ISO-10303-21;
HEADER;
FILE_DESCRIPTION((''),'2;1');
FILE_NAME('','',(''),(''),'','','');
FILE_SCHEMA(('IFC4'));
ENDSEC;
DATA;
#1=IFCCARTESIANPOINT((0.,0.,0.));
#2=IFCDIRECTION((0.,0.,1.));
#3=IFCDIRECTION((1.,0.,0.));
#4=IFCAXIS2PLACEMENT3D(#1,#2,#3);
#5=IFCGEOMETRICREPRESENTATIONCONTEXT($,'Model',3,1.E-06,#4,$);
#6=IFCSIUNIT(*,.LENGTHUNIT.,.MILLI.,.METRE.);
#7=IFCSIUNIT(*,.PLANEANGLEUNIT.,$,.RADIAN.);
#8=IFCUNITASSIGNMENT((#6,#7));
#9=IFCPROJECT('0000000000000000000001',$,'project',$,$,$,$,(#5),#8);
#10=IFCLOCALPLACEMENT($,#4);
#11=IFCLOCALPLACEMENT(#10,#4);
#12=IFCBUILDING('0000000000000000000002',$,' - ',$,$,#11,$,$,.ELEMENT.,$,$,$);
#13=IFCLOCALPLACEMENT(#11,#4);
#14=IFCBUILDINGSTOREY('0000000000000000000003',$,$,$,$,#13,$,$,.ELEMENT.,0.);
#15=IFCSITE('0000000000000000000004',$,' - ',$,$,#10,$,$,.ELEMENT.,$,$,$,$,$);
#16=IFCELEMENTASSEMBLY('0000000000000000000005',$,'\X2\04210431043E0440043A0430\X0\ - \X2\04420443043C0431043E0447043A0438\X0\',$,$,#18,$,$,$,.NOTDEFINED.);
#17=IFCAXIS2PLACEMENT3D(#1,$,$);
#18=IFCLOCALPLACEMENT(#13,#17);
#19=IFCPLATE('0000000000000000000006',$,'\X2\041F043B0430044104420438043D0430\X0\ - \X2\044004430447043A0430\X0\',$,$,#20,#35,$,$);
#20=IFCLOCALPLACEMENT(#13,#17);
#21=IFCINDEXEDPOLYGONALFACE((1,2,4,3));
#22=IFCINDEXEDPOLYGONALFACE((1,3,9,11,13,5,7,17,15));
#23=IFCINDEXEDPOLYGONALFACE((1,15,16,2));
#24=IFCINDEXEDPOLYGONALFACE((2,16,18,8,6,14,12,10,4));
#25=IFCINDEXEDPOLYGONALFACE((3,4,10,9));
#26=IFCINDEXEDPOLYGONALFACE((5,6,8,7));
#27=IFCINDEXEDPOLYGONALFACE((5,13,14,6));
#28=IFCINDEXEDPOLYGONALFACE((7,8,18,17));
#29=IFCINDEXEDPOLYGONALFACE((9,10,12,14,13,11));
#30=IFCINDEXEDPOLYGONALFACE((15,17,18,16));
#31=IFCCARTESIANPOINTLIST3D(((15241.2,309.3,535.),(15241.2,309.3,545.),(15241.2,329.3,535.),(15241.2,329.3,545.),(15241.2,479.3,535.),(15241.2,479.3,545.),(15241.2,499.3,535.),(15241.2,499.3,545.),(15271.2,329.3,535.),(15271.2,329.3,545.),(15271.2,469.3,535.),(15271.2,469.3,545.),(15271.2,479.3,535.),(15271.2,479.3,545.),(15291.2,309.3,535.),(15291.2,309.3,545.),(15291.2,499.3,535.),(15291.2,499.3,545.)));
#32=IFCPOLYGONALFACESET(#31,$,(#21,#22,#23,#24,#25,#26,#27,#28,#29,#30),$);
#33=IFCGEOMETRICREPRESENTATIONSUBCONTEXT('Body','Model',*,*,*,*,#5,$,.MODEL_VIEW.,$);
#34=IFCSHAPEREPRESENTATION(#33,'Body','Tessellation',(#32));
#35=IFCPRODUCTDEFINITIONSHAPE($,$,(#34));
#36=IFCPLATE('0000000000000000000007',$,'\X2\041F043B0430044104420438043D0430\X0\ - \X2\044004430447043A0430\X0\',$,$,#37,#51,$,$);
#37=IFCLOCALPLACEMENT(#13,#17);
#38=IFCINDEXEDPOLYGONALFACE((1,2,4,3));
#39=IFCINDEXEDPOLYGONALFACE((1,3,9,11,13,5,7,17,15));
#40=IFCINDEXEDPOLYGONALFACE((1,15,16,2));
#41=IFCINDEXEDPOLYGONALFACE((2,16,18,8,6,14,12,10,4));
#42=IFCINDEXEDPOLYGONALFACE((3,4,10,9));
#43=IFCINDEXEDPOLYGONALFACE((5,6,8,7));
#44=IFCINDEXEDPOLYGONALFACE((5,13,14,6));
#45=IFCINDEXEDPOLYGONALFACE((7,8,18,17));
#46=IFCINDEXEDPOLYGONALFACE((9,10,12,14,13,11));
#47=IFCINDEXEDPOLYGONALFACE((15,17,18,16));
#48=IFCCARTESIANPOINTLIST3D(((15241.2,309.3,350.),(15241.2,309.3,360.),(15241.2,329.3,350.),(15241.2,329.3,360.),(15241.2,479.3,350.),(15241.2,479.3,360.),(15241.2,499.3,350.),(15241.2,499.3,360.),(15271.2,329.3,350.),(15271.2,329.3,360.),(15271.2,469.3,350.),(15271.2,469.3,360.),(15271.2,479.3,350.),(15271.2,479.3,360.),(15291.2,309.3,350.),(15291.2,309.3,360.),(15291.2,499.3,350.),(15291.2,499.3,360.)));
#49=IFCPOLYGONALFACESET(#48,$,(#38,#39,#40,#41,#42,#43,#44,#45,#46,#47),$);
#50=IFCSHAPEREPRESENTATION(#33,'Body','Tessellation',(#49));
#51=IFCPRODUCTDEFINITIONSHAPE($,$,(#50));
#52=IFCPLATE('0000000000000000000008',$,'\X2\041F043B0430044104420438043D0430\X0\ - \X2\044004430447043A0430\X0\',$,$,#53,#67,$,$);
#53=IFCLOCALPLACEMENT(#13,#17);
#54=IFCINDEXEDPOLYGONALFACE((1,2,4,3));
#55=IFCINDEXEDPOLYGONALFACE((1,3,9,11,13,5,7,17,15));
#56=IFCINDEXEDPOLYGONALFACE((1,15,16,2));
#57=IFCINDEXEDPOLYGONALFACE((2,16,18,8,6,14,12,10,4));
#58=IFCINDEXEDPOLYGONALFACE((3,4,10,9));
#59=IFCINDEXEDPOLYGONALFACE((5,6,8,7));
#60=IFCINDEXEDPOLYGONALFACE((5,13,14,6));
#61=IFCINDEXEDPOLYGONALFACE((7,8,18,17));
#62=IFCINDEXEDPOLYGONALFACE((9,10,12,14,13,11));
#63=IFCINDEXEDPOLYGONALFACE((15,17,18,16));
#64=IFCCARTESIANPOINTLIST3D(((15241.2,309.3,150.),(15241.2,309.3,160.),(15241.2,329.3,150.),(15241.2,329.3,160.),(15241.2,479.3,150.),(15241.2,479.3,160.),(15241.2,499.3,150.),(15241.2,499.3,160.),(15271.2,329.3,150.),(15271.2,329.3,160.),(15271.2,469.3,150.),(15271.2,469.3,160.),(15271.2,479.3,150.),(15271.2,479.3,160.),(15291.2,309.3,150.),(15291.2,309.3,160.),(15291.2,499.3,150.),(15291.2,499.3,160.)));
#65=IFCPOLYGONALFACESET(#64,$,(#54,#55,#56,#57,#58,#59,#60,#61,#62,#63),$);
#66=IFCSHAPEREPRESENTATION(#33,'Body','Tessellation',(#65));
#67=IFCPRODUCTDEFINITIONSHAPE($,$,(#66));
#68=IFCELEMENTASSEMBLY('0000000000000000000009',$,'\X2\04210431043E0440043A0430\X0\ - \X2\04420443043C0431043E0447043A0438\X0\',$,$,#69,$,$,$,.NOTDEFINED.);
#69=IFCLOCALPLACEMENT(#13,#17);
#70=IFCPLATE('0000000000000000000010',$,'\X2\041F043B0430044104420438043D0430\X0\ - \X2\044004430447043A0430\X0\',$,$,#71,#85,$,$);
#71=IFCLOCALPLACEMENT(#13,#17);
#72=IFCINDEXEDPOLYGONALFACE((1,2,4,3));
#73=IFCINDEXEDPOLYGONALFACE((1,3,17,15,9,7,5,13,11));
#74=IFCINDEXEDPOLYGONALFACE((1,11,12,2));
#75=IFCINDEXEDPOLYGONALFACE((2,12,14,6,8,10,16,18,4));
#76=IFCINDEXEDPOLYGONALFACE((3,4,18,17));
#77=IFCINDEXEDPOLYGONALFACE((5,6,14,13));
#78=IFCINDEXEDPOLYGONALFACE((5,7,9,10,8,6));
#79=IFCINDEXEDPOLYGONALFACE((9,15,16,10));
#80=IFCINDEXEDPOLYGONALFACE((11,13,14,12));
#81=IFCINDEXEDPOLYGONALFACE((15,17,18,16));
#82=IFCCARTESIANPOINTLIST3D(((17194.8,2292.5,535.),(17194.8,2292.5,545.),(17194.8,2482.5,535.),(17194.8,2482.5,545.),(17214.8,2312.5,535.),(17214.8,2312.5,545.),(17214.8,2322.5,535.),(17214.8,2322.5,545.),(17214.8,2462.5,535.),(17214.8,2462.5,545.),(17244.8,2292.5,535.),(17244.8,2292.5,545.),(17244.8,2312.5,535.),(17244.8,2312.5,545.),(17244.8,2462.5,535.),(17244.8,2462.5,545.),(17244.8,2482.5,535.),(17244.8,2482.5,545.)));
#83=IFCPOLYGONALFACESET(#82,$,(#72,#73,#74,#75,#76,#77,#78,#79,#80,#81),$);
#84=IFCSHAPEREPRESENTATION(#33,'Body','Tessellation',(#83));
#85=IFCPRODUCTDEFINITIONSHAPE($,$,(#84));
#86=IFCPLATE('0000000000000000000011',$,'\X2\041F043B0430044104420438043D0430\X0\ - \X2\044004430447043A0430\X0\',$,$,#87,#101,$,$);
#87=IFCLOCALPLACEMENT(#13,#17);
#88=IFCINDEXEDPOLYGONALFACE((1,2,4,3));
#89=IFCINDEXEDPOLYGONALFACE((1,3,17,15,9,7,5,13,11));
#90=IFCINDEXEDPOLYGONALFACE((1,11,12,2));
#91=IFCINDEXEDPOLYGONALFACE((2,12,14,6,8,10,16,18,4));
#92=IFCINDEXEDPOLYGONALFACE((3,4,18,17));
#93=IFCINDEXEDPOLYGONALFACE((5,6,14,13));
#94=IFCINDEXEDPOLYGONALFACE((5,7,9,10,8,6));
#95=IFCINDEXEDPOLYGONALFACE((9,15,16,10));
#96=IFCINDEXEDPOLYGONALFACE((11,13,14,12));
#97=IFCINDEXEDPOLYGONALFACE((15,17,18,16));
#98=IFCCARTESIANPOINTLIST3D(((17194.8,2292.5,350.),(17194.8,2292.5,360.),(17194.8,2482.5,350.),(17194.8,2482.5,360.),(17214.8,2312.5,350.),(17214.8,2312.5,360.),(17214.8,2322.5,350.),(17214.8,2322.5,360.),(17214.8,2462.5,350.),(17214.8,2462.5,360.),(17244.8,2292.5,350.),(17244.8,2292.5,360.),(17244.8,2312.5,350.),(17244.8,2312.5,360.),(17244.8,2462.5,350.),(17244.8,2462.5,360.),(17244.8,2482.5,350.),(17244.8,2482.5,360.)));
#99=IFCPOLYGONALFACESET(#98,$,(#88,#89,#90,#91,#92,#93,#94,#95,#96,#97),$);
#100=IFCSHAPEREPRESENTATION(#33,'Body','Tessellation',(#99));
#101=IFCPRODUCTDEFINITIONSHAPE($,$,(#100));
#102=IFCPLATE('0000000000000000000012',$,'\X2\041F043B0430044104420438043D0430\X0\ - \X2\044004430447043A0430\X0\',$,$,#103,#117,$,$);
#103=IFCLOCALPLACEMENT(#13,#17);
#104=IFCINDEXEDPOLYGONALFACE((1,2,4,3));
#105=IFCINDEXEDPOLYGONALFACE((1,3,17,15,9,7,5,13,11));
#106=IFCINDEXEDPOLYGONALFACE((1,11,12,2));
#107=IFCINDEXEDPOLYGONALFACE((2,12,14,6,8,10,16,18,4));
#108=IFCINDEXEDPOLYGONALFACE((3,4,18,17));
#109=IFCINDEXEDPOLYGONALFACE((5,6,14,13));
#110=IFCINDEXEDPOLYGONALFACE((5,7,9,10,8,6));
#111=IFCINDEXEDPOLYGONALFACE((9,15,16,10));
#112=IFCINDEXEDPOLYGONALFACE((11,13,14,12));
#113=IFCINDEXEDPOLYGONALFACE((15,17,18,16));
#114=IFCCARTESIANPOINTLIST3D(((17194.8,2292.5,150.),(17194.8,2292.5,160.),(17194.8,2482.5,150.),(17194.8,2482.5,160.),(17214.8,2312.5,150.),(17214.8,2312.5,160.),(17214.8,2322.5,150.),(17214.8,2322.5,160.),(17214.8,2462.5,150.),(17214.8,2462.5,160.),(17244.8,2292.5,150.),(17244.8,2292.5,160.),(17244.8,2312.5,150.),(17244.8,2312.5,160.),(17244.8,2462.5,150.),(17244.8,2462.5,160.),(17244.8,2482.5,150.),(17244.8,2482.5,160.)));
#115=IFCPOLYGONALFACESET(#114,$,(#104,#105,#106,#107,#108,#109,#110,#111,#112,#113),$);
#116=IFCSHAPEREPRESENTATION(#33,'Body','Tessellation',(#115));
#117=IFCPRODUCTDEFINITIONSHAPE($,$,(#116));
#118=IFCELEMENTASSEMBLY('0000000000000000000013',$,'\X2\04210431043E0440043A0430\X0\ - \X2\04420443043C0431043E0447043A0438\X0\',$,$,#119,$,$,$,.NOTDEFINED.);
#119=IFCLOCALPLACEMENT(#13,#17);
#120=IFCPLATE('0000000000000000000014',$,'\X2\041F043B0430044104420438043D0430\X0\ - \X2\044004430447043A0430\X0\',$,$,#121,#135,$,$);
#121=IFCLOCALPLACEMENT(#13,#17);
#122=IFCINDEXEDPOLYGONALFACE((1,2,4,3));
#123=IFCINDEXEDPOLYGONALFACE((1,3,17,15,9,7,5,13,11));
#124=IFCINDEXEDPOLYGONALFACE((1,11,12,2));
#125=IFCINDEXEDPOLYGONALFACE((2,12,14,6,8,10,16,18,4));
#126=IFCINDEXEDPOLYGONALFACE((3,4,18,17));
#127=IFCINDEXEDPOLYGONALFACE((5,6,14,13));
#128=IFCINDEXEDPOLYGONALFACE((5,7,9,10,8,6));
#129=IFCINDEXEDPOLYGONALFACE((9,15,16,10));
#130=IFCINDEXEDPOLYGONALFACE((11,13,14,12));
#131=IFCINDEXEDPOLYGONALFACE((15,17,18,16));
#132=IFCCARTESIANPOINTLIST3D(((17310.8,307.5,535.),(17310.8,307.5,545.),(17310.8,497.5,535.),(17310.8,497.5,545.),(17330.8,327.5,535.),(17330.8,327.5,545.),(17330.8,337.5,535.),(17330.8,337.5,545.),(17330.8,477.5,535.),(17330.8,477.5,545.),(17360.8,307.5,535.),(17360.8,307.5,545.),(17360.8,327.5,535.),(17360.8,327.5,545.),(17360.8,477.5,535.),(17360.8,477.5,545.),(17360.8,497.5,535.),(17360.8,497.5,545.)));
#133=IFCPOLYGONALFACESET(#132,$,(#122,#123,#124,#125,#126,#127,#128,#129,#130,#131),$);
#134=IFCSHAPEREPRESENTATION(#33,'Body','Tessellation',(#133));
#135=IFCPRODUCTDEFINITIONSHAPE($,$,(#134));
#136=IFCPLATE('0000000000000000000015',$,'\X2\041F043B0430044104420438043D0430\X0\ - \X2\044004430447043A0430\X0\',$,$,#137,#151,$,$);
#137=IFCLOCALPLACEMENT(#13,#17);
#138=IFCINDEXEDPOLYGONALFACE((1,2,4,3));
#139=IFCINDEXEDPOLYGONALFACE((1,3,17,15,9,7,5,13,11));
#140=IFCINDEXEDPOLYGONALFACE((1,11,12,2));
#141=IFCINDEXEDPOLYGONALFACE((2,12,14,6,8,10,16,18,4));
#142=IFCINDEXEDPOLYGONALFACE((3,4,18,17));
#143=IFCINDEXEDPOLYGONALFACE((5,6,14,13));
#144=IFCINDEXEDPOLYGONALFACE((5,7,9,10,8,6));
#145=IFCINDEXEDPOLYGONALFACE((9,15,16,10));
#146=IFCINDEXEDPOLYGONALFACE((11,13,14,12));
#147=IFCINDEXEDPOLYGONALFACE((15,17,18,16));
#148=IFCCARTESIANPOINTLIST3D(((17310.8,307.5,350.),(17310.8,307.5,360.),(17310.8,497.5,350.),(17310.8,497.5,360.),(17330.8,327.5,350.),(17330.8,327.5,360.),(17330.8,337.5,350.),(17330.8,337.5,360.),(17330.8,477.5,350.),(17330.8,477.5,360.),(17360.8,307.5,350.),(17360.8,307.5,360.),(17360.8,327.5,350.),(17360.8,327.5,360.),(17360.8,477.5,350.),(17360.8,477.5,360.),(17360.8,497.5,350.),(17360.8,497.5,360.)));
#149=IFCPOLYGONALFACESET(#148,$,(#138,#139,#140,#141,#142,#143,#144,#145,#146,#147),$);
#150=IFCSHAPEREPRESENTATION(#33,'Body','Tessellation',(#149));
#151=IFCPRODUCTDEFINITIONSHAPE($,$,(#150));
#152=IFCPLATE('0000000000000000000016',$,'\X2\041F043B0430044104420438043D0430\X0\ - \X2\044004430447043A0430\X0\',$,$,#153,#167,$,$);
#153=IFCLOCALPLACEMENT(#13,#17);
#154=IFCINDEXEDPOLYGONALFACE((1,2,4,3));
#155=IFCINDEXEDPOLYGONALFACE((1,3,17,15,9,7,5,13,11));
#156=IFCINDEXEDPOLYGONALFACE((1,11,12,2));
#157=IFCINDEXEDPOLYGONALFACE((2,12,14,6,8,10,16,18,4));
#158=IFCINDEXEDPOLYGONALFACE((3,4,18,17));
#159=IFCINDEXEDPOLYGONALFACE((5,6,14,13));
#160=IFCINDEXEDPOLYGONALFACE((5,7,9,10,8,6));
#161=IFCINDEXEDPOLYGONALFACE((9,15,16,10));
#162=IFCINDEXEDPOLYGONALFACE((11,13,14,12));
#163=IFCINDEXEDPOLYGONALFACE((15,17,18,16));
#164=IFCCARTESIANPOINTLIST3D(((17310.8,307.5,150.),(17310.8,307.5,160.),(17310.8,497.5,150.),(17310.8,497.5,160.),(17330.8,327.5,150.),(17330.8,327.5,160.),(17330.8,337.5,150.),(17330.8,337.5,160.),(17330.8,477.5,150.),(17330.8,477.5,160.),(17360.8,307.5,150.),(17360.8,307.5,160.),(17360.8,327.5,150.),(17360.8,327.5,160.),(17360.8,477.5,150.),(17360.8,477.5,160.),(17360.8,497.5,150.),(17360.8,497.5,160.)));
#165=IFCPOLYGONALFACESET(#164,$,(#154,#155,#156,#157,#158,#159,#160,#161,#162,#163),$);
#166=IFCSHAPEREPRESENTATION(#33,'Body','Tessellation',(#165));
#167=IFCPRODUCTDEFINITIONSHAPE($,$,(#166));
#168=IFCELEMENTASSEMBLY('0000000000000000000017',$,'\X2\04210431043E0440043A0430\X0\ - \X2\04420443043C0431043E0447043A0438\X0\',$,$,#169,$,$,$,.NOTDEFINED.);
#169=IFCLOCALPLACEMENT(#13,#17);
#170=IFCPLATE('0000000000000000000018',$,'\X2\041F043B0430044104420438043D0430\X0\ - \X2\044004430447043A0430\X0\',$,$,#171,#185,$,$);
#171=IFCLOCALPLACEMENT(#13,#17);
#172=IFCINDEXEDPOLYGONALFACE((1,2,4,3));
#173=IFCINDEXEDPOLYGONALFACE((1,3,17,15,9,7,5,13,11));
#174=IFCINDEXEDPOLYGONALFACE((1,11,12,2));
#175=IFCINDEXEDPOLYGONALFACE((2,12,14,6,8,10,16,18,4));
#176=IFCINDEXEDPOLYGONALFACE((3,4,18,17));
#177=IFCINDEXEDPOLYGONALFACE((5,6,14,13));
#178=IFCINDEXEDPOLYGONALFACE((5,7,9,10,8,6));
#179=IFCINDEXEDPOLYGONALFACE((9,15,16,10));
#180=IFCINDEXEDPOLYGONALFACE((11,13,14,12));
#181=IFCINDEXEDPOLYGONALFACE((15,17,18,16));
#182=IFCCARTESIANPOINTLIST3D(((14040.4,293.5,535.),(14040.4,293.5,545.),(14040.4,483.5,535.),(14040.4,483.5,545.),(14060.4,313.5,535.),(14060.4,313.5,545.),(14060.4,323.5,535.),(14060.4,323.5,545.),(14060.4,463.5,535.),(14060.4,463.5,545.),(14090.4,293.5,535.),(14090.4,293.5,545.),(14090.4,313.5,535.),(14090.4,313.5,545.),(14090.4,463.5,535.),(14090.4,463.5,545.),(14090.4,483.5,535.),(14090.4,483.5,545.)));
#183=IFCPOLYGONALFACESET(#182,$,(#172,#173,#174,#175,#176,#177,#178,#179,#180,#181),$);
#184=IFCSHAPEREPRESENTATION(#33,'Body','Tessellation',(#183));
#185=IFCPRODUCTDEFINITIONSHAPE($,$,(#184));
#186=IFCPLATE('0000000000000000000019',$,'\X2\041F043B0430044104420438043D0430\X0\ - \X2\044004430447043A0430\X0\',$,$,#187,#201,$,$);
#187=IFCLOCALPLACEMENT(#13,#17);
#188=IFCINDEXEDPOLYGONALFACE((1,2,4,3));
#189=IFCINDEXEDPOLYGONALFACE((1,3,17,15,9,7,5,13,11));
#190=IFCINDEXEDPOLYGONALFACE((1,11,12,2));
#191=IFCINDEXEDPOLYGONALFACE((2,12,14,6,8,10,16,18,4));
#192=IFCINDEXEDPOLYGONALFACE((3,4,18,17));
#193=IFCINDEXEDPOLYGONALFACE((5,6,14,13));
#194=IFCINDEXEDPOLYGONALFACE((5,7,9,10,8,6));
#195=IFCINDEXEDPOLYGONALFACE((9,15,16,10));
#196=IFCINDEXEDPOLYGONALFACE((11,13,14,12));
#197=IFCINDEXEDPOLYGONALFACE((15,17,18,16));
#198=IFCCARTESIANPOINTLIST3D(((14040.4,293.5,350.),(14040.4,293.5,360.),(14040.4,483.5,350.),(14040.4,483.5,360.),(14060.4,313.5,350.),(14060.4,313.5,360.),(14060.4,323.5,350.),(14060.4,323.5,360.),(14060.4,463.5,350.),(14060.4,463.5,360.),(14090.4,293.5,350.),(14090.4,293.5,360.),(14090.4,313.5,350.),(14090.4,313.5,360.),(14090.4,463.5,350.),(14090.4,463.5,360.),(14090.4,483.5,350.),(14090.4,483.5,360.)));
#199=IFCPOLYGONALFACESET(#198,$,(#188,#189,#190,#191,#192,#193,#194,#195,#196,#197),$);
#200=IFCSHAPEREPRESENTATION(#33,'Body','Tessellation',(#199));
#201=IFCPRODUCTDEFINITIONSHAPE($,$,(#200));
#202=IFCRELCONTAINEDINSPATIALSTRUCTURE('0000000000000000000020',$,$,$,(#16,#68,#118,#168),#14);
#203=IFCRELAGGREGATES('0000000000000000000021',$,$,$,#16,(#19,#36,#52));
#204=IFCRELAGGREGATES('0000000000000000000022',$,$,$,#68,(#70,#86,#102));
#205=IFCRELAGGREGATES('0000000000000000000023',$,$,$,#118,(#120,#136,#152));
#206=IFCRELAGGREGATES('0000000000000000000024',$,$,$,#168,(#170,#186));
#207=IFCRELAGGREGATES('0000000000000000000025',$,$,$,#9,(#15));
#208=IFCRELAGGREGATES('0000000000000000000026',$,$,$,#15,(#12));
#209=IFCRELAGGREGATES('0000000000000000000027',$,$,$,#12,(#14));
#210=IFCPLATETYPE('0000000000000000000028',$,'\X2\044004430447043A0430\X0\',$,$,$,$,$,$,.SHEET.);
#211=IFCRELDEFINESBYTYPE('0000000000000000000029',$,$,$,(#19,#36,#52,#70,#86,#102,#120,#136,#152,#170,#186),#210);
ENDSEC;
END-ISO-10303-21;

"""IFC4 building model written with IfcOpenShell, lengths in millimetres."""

from ifc_helpers import new_model, si_unit, frame, origin_with_axes, place, context, subcontext, project, spatial, line, indexed_curve, outline, extrude, source, transform, mapped, type_object, element, aggregate, save


model = new_model("IFC4")

# Units and contexts
model_context = context("Model", 3, precision=1e-06, world=origin_with_axes())
body_context = subcontext(model_context, "Body", "Model", "MODEL_VIEW")
ifc_project = project(units=[si_unit("LENGTHUNIT", "METRE", prefix="MILLI"), si_unit("PLANEANGLEUNIT", "RADIAN")], contexts=[model_context])

# Site, building, storey
site_placement = place(None, origin_with_axes())
site = spatial("IfcSite", under=ifc_project, at=site_placement, Name=" - ", CompositionType="ELEMENT")
building_placement = place(site_placement, origin_with_axes())
building = spatial("IfcBuilding", under=site, at=building_placement, Name=" - ", CompositionType="ELEMENT")
storey_placement = place(building_placement, origin_with_axes())
storey = spatial("IfcBuildingStorey", under=building, at=storey_placement, CompositionType="ELEMENT", Elevation=0.0)

# Shared definitions
plate_type = type_object("IfcPlateType", Name="ручка", PredefinedType="SHEET")
shared_shape = source(origin_with_axes(), body_context, "Body", "SweptSolid", [
    extrude(outline(indexed_curve([(-95.0, -25.0), (-75.0, -25.0), (-75.0, 5.0), (-65.0, 5.0), (75.0, 5.0), (75.0, -25.0), (95.0, -25.0), (95.0, 25.0), (-95.0, 25.0)], segments=[line(1, 2), line(2, 3), line(3, 4), line(4, 5), line(5, 6), line(6, 7), line(7, 8), line(8, 9), line(9, 1)])), origin_with_axes(), (0.0, 0.0, 1.0), 10.0),
])

# Element assemblies, plates
assembly_1_placement = place(storey_placement, frame((15241.2, 204.3, 0.0), z_axis=(0.0, 0.0, 1.0), x_axis=(0.0, 1.0, 0.0)))
assembly_1 = element("IfcElementAssembly", 1, at=assembly_1_placement, inside=storey, Name="Сборка - тумбочки", PredefinedType="NOTDEFINED")
plate_1_placement = place(assembly_1_placement, frame((200.0, -25.0, 535.0), z_axis=(0.0, 0.0, 1.0), x_axis=(-1.0, 0.0, 0.0)))
plate_1 = element("IfcPlate", 2, at=plate_1_placement, type_object=plate_type, Name="Пластина - ручка", context=body_context, shape_type="MappedRepresentation", body=[
    mapped(shared_shape, transform((0.0, 0.0, 0.0), x_axis=(1.0, 0.0, 0.0), y_axis=(0.0, 1.0, 0.0), z_axis=(0.0, 0.0, 1.0), scale=1.0)),
])
plate_2_placement = place(assembly_1_placement, frame((200.0, -25.0, 350.0), z_axis=(0.0, 0.0, 1.0), x_axis=(-1.0, 0.0, 0.0)))
plate_2 = element("IfcPlate", 3, at=plate_2_placement, type_object=plate_type, Name="Пластина - ручка", context=body_context, shape_type="MappedRepresentation", body=[
    mapped(shared_shape, transform((0.0, 0.0, 0.0), x_axis=(1.0, 0.0, 0.0), y_axis=(0.0, 1.0, 0.0), z_axis=(0.0, 0.0, 1.0), scale=1.0)),
])
plate_3_placement = place(assembly_1_placement, frame((200.0, -25.0, 150.0), z_axis=(0.0, 0.0, 1.0), x_axis=(-1.0, 0.0, 0.0)))
plate_3 = element("IfcPlate", 4, at=plate_3_placement, type_object=plate_type, Name="Пластина - ручка", context=body_context, shape_type="MappedRepresentation", body=[
    mapped(shared_shape, transform((0.0, 0.0, 0.0), x_axis=(1.0, 0.0, 0.0), y_axis=(0.0, 1.0, 0.0), z_axis=(0.0, 0.0, 1.0), scale=1.0)),
])
aggregate(assembly_1, [plate_1, plate_2, plate_3])
assembly_2_placement = place(storey_placement, frame((17244.8, 2587.5, 0.0), z_axis=(0.0, 0.0, 1.0), x_axis=(0.0, -1.0, 0.0)))
assembly_2 = element("IfcElementAssembly", 5, at=assembly_2_placement, inside=storey, Name="Сборка - тумбочки", PredefinedType="NOTDEFINED")
plate_4_placement = place(assembly_2_placement, frame((200.0, -25.0, 535.0), z_axis=(0.0, 0.0, 1.0), x_axis=(-1.0, 0.0, 0.0)))
plate_4 = element("IfcPlate", 6, at=plate_4_placement, type_object=plate_type, Name="Пластина - ручка", context=body_context, shape_type="MappedRepresentation", body=[
    mapped(shared_shape, transform((0.0, 0.0, 0.0), x_axis=(1.0, 0.0, 0.0), y_axis=(0.0, 1.0, 0.0), z_axis=(0.0, 0.0, 1.0), scale=1.0)),
])
plate_5_placement = place(assembly_2_placement, frame((200.0, -25.0, 350.0), z_axis=(0.0, 0.0, 1.0), x_axis=(-1.0, 0.0, 0.0)))
plate_5 = element("IfcPlate", 7, at=plate_5_placement, type_object=plate_type, Name="Пластина - ручка", context=body_context, shape_type="MappedRepresentation", body=[
    mapped(shared_shape, transform((0.0, 0.0, 0.0), x_axis=(1.0, 0.0, 0.0), y_axis=(0.0, 1.0, 0.0), z_axis=(0.0, 0.0, 1.0), scale=1.0)),
])
plate_6_placement = place(assembly_2_placement, frame((200.0, -25.0, 150.0), z_axis=(0.0, 0.0, 1.0), x_axis=(-1.0, 0.0, 0.0)))
plate_6 = element("IfcPlate", 8, at=plate_6_placement, type_object=plate_type, Name="Пластина - ручка", context=body_context, shape_type="MappedRepresentation", body=[
    mapped(shared_shape, transform((0.0, 0.0, 0.0), x_axis=(1.0, 0.0, 0.0), y_axis=(0.0, 1.0, 0.0), z_axis=(0.0, 0.0, 1.0), scale=1.0)),
])
aggregate(assembly_2, [plate_4, plate_5, plate_6])
assembly_3_placement = place(storey_placement, frame((17360.8, 602.5, 0.0), z_axis=(0.0, 0.0, 1.0), x_axis=(0.0, -1.0, 0.0)))
assembly_3 = element("IfcElementAssembly", 9, at=assembly_3_placement, inside=storey, Name="Сборка - тумбочки", PredefinedType="NOTDEFINED")
plate_7_placement = place(assembly_3_placement, frame((200.0, -25.0, 535.0), z_axis=(0.0, 0.0, 1.0), x_axis=(-1.0, 0.0, 0.0)))
plate_7 = element("IfcPlate", 10, at=plate_7_placement, type_object=plate_type, Name="Пластина - ручка", context=body_context, shape_type="MappedRepresentation", body=[
    mapped(shared_shape, transform((0.0, 0.0, 0.0), x_axis=(1.0, 0.0, 0.0), y_axis=(0.0, 1.0, 0.0), z_axis=(0.0, 0.0, 1.0), scale=1.0)),
])
plate_8_placement = place(assembly_3_placement, frame((200.0, -25.0, 350.0), z_axis=(0.0, 0.0, 1.0), x_axis=(-1.0, 0.0, 0.0)))
plate_8 = element("IfcPlate", 11, at=plate_8_placement, type_object=plate_type, Name="Пластина - ручка", context=body_context, shape_type="MappedRepresentation", body=[
    mapped(shared_shape, transform((0.0, 0.0, 0.0), x_axis=(1.0, 0.0, 0.0), y_axis=(0.0, 1.0, 0.0), z_axis=(0.0, 0.0, 1.0), scale=1.0)),
])
plate_9_placement = place(assembly_3_placement, frame((200.0, -25.0, 150.0), z_axis=(0.0, 0.0, 1.0), x_axis=(-1.0, 0.0, 0.0)))
plate_9 = element("IfcPlate", 12, at=plate_9_placement, type_object=plate_type, Name="Пластина - ручка", context=body_context, shape_type="MappedRepresentation", body=[
    mapped(shared_shape, transform((0.0, 0.0, 0.0), x_axis=(1.0, 0.0, 0.0), y_axis=(0.0, 1.0, 0.0), z_axis=(0.0, 0.0, 1.0), scale=1.0)),
])
aggregate(assembly_3, [plate_7, plate_8, plate_9])
assembly_4_placement = place(storey_placement, frame((14090.4, 588.5, 0.0), z_axis=(0.0, 0.0, 1.0), x_axis=(0.0, -1.0, 0.0)))
assembly_4 = element("IfcElementAssembly", 13, at=assembly_4_placement, inside=storey, Name="Сборка - тумбочки", PredefinedType="NOTDEFINED")
plate_10_placement = place(assembly_4_placement, frame((200.0, -25.0, 535.0), z_axis=(0.0, 0.0, 1.0), x_axis=(-1.0, 0.0, 0.0)))
plate_10 = element("IfcPlate", 14, at=plate_10_placement, type_object=plate_type, Name="Пластина - ручка", context=body_context, shape_type="MappedRepresentation", body=[
    mapped(shared_shape, transform((0.0, 0.0, 0.0), x_axis=(1.0, 0.0, 0.0), y_axis=(0.0, 1.0, 0.0), z_axis=(0.0, 0.0, 1.0), scale=1.0)),
])
plate_11_placement = place(assembly_4_placement, frame((200.0, -25.0, 350.0), z_axis=(0.0, 0.0, 1.0), x_axis=(-1.0, 0.0, 0.0)))
plate_11 = element("IfcPlate", 15, at=plate_11_placement, type_object=plate_type, Name="Пластина - ручка", context=body_context, shape_type="MappedRepresentation", body=[
    mapped(shared_shape, transform((0.0, 0.0, 0.0), x_axis=(1.0, 0.0, 0.0), y_axis=(0.0, 1.0, 0.0), z_axis=(0.0, 0.0, 1.0), scale=1.0)),
])
aggregate(assembly_4, [plate_10, plate_11])

save(model, "model.ifc")
